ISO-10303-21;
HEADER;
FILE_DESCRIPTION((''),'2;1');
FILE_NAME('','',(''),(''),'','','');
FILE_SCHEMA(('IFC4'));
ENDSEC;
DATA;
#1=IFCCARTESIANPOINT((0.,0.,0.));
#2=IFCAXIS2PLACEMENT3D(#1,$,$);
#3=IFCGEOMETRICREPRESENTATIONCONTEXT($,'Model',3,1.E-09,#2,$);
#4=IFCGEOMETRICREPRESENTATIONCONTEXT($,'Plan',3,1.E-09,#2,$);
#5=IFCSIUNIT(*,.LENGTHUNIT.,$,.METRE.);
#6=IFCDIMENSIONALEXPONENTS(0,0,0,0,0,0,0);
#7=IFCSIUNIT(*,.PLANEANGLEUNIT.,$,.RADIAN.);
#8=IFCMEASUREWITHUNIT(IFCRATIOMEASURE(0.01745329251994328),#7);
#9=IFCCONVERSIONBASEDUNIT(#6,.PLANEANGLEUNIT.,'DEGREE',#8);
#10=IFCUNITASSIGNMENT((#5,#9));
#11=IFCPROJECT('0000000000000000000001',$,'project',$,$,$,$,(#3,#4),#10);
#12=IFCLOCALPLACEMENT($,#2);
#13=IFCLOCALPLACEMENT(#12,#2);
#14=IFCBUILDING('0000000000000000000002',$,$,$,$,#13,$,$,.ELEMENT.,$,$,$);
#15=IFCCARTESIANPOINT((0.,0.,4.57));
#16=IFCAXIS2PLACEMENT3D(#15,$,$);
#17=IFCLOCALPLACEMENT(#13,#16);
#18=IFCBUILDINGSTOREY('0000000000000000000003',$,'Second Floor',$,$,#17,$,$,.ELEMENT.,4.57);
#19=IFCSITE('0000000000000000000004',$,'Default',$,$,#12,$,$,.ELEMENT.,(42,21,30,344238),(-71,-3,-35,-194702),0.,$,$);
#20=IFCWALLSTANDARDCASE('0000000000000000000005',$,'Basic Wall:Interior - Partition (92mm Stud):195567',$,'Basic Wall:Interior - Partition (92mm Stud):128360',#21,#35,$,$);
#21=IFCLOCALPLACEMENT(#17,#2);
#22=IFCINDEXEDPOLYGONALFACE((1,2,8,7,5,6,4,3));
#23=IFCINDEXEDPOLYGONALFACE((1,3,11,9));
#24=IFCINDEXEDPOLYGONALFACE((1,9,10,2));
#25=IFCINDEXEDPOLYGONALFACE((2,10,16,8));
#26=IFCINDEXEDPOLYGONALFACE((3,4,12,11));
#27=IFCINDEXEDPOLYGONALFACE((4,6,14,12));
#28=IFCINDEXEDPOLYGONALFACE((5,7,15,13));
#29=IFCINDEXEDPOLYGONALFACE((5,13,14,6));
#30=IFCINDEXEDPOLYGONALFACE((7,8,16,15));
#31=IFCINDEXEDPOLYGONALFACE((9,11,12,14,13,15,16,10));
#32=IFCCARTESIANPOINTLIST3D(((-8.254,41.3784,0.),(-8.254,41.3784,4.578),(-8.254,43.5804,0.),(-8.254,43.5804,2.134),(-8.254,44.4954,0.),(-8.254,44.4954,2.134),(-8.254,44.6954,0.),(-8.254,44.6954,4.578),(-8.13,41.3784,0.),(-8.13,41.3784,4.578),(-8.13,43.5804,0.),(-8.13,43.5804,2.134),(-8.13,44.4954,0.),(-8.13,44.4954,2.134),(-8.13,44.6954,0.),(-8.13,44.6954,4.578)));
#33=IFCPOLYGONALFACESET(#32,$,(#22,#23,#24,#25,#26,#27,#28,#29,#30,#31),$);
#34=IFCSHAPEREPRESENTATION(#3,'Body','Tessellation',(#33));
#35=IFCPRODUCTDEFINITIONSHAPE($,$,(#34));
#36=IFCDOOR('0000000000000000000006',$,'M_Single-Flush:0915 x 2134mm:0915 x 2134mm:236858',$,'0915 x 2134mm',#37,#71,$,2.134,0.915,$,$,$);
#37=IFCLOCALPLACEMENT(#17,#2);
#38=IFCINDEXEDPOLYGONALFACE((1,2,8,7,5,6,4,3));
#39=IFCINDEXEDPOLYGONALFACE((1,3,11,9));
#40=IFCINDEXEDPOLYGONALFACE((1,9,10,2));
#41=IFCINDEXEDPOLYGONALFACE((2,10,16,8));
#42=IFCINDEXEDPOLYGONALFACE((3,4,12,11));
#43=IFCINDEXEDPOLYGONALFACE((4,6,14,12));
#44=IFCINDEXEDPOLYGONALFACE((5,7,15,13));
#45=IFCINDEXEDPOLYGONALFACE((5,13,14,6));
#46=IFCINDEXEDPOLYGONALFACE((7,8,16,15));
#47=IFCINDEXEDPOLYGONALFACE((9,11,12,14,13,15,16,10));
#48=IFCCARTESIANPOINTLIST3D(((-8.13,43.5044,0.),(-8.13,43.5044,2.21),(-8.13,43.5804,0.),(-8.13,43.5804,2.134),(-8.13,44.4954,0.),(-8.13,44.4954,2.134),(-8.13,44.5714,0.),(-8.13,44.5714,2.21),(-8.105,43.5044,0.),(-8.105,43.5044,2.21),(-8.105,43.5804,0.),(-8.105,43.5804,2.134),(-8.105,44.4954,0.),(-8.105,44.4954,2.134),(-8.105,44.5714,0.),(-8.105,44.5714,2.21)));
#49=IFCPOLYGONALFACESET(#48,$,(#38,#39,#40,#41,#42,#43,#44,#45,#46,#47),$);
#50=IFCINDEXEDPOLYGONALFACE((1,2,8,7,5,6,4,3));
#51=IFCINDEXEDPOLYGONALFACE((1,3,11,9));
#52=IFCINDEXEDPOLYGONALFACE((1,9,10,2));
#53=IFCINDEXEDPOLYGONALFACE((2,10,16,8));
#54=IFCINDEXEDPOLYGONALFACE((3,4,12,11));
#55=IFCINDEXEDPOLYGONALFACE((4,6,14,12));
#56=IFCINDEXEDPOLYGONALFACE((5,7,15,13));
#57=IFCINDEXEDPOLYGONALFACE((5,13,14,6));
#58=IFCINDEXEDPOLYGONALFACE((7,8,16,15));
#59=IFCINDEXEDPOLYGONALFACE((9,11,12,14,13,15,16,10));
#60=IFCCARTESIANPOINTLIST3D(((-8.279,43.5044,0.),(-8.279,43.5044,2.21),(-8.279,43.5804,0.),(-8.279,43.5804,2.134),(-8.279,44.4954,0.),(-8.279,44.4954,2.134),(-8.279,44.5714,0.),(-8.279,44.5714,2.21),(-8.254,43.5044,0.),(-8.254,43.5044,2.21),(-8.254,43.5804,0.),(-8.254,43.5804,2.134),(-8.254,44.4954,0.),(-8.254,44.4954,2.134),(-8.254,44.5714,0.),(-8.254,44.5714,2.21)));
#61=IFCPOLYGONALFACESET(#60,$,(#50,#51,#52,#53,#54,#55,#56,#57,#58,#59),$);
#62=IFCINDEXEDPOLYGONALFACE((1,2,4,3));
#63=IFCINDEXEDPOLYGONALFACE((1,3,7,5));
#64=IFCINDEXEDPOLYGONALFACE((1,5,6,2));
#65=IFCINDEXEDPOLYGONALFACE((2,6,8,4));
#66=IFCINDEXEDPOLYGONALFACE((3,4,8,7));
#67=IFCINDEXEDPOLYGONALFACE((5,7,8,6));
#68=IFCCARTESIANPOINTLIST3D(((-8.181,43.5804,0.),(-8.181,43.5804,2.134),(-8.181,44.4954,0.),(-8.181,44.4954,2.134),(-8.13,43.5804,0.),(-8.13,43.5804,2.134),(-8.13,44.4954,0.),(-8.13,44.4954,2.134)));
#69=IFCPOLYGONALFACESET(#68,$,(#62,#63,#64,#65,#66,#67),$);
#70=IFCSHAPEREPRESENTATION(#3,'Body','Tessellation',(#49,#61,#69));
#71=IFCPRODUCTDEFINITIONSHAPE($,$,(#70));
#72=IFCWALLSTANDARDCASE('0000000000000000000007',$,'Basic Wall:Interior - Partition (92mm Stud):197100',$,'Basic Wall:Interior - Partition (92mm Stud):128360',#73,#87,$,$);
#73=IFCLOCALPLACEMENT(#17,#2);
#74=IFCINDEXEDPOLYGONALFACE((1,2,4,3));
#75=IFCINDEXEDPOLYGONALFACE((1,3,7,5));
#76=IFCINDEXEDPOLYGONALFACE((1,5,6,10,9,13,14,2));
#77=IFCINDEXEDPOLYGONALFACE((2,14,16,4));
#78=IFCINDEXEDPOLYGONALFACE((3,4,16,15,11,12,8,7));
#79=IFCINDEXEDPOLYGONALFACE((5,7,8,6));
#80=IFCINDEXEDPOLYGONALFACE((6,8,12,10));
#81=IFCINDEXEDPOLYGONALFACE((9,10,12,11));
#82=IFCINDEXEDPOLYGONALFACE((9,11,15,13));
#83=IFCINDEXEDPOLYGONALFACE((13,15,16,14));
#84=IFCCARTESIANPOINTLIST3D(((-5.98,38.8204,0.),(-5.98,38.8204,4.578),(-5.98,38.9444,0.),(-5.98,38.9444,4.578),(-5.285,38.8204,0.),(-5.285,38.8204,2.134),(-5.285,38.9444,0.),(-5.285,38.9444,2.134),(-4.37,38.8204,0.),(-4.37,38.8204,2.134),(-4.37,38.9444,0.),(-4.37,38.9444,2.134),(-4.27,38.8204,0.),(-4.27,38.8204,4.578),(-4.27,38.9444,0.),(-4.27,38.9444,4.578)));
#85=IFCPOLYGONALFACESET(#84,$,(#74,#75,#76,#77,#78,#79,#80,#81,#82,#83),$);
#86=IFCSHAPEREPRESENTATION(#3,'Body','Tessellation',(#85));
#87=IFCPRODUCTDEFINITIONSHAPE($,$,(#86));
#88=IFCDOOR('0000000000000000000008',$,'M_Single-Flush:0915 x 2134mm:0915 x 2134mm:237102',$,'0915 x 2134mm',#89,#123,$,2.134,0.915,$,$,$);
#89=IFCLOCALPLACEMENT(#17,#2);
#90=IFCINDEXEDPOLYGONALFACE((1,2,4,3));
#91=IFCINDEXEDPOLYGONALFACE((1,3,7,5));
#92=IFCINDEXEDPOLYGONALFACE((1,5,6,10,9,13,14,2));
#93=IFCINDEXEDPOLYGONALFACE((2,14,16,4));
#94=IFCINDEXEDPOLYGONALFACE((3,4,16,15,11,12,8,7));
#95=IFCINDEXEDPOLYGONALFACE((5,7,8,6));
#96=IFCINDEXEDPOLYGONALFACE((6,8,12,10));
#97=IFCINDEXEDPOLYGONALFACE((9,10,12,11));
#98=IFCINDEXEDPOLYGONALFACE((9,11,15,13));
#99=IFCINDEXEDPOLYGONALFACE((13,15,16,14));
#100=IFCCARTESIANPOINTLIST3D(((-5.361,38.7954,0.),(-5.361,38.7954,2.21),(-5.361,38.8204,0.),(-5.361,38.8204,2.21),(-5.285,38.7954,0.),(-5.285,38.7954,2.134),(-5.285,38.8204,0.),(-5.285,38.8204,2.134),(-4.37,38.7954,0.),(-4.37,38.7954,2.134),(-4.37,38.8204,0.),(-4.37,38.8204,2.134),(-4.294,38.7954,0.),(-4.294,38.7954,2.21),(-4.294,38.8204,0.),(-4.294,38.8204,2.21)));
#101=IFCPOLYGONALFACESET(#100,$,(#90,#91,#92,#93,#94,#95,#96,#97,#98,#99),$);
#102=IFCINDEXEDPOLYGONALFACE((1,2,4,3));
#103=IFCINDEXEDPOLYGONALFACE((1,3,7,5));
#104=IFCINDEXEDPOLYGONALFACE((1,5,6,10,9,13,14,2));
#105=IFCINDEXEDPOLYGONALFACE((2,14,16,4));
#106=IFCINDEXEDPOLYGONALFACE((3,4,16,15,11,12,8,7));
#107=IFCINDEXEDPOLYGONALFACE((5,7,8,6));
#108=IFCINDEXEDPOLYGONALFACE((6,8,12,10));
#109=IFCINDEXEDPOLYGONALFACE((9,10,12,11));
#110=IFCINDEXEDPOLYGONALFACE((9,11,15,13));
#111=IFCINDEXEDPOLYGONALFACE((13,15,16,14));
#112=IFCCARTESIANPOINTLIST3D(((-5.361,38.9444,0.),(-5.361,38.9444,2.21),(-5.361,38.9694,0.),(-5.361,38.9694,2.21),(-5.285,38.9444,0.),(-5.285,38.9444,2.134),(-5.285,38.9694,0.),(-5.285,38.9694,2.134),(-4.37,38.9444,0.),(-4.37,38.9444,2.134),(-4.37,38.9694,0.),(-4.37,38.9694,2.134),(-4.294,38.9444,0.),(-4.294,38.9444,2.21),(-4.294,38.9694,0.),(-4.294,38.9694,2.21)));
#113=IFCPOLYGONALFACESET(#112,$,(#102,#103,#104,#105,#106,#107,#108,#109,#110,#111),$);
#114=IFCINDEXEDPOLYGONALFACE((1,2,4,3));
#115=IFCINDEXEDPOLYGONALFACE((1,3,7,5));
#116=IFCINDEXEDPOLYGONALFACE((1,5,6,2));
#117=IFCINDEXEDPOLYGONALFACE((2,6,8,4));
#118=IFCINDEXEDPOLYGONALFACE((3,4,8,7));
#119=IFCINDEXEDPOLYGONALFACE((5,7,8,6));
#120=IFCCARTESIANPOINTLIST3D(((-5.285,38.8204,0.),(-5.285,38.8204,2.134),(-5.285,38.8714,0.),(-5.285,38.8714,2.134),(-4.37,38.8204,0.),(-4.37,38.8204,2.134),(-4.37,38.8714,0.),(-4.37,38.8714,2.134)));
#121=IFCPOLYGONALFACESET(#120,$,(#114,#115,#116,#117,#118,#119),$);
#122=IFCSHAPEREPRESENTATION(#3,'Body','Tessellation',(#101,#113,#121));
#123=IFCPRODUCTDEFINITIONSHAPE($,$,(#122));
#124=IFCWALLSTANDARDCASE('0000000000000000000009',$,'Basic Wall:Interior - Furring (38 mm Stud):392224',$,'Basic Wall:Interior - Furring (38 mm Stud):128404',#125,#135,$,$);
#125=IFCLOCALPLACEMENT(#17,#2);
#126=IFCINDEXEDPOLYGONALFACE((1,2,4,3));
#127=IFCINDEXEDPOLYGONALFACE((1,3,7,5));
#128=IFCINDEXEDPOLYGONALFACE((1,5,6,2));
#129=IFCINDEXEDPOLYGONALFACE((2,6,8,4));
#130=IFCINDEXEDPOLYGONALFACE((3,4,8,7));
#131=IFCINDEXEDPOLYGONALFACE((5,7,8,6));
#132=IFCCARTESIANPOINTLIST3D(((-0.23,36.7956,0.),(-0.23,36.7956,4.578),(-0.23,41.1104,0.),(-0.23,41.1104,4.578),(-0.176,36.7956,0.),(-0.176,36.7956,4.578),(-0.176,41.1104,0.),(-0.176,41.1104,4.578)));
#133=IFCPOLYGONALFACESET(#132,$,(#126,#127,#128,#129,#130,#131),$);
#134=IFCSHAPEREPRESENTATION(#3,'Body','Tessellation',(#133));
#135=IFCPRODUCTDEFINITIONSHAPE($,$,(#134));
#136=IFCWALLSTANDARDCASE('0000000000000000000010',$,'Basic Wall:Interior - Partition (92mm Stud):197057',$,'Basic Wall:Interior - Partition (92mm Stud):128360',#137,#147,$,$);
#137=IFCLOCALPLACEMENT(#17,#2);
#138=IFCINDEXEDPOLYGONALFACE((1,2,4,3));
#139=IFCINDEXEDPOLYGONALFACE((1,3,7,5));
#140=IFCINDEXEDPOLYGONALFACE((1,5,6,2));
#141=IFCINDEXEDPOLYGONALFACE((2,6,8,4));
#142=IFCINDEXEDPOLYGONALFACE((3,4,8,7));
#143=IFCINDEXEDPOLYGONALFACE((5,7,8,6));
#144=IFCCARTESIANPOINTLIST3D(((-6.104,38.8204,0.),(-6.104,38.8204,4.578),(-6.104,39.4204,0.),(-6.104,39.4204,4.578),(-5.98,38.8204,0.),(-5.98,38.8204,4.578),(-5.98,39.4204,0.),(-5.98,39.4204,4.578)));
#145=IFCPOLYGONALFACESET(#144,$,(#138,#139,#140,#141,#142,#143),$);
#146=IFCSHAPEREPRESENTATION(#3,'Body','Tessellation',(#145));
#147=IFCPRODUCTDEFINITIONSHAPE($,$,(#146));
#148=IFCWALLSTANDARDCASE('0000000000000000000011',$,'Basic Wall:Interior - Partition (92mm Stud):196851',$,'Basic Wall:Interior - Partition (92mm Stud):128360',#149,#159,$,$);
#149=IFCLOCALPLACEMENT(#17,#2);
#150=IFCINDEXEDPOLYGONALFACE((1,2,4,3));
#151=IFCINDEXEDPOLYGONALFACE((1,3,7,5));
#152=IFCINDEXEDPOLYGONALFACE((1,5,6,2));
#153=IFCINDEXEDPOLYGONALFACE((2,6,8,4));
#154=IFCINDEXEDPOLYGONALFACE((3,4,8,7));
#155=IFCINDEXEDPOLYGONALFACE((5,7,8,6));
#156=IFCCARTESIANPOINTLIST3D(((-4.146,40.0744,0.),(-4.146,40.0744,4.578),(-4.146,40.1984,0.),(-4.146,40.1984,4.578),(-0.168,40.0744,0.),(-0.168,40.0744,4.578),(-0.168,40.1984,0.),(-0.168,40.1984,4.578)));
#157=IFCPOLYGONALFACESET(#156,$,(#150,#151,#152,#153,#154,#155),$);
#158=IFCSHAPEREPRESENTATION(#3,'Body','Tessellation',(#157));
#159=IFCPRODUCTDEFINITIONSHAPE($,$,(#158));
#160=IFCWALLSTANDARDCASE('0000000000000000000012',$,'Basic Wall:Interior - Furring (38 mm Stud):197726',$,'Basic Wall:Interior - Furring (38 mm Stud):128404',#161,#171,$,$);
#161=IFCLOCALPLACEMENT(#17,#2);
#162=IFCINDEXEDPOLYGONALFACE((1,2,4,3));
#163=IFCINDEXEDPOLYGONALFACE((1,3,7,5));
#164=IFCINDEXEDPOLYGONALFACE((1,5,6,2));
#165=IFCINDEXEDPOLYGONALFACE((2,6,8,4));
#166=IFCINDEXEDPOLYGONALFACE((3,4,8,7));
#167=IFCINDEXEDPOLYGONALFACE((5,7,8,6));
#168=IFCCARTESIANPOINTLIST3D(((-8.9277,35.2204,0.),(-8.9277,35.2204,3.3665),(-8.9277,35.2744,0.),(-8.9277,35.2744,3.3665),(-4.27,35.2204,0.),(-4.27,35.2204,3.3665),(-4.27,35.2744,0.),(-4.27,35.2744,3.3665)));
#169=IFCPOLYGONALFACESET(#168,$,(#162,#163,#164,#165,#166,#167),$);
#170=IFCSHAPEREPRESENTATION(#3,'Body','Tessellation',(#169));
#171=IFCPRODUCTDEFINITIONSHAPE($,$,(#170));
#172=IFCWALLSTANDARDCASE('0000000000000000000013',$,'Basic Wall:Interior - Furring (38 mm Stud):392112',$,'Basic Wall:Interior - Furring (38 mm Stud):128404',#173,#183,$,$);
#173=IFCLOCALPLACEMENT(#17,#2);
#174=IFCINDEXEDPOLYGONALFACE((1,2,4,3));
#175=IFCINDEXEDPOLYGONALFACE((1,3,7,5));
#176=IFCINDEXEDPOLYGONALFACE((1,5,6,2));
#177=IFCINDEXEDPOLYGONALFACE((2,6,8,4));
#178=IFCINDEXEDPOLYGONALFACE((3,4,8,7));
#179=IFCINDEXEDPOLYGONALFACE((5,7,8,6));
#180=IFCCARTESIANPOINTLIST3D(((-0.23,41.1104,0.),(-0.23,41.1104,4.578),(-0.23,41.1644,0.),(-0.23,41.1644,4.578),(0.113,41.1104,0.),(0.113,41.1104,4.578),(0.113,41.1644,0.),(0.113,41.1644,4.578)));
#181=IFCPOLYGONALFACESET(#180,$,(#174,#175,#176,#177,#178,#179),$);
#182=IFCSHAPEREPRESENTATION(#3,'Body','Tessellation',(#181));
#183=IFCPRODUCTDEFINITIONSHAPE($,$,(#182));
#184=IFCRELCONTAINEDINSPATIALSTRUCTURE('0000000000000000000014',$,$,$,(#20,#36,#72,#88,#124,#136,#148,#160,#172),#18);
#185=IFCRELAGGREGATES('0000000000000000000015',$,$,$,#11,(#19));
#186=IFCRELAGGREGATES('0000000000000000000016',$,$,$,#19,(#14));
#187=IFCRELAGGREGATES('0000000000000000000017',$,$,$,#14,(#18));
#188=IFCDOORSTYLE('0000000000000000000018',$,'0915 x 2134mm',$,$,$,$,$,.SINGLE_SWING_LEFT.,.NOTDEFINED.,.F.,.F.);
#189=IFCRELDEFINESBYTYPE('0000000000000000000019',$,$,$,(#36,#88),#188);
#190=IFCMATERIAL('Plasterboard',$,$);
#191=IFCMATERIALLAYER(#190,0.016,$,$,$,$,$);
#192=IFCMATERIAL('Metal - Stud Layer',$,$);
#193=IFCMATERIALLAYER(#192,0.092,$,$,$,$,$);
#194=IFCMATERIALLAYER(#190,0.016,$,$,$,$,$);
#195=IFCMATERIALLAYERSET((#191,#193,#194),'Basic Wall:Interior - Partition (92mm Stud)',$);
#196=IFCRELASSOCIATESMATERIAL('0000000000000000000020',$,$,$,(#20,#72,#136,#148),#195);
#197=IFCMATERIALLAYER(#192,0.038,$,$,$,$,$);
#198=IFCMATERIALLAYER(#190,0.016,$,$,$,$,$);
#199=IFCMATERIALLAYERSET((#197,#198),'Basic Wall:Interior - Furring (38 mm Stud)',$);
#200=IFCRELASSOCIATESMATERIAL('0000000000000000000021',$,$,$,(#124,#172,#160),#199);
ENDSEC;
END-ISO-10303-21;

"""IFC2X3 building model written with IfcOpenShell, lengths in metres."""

from ifc_helpers import new_model, entity, si_unit, converted_unit, frame, frame_2d, origin, origin_2d_with_axis, place, context, project, spatial, polyline, rectangle, outline, extrude, source, transform, mapped, material, layer, layer_set, layer_usage, type_object, type_shapes, element, fill, save


model = new_model("IFC2X3")

# Units and contexts
model_context = context("Model", 3, precision=1e-09, world=origin())
plan_context = context("Plan", 3, precision=1e-09, world=origin())
ifc_project = project(units=[si_unit("LENGTHUNIT", "METRE"), converted_unit("PLANEANGLEUNIT", "DEGREE", entity("IfcRatioMeasure", 0.01745329251994328), si_unit("PLANEANGLEUNIT", "RADIAN"), dimensions=[0, 0, 0, 0, 0, 0, 0])], contexts=[model_context, plan_context])

# Site, building, storey
site_placement = place(None, origin())
site = spatial("IfcSite", under=ifc_project, at=site_placement, Name="Default", CompositionType="ELEMENT", RefLatitude=(42, 21, 30, 344238), RefLongitude=(-71, -3, -35, -194702), RefElevation=0.0)
building_placement = place(site_placement, origin())
building = spatial("IfcBuilding", under=site, at=building_placement, CompositionType="ELEMENT")
storey_placement = place(building_placement, frame((0.0, 0.0, 4.57)))
storey = spatial("IfcBuildingStorey", under=building, at=storey_placement, Name="Second Floor", CompositionType="ELEMENT", Elevation=4.57)

# Shared definitions
ifc_material_1 = material(Name="Plasterboard")
ifc_layer_1 = layer(ifc_material_1, 0.016)
ifc_material_2 = material(Name="Metal - Stud Layer")
ifc_layer_2 = layer(ifc_material_2, 0.092)
ifc_layer_3 = layer(ifc_material_1, 0.016)
ifc_layer_set_1 = layer_set([ifc_layer_1, ifc_layer_2, ifc_layer_3], Name="Basic Wall:Interior - Partition (92mm Stud)")
ifc_layer_usage_1 = layer_usage(ifc_layer_set_1, "AXIS2", "NEGATIVE", 0.062)
door_style_1 = type_object("IfcDoorStyle", Name="0915 x 2134mm", ConstructionType="NOTDEFINED", OperationType="SINGLE_SWING_LEFT", ParameterTakesPrecedence=False, Sizeable=False)
shared_shape_1 = source(origin(), model_context, "Body", "SweptSolid", [
    extrude(outline(polyline([(-0.5335, -1.124), (0.5335, -1.124), (0.5335, 1.086), (0.4575, 1.086), (0.4575, -1.048), (-0.4575, -1.048), (-0.4575, 1.086), (-0.5335, 1.086), (-0.5335, -1.124)])), frame((0.4575, 0.149, 1.086), z_axis=(0.0, -1.0, 0.0), x_axis=(-1.0, 0.0, 0.0)), (0.0, 0.0, 1.0), 0.025),
    extrude(outline(polyline([(-1.124, -0.5335), (1.086, -0.5335), (1.086, -0.4575), (-1.048, -0.4575), (-1.048, 0.4575), (1.086, 0.4575), (1.086, 0.5335), (-1.124, 0.5335), (-1.124, -0.5335)])), frame((0.4575, 0.0, 1.086), z_axis=(0.0, -1.0, 0.0), x_axis=(0.0, 0.0, -1.0)), (0.0, 0.0, 1.0), 0.025),
    extrude(rectangle(XDim=0.915, YDim=0.051, at=origin_2d_with_axis()), frame((0.4575, 0.0985, 0.0)), (0.0, 0.0, 1.0), 2.134),
])
type_shapes(door_style_1, [shared_shape_1])

# Wall, opening, door
wall_1_placement = place(storey_placement, frame((-8.192, 41.3784, 0.0), z_axis=(0.0, 0.0, 1.0), x_axis=(0.0, 1.0, 0.0)))
wall_1 = element("IfcWallStandardCase", 1, at=wall_1_placement, inside=storey, material=ifc_layer_usage_1, Name="Basic Wall:Interior - Partition (92mm Stud):195567", ObjectType="Basic Wall:Interior - Partition (92mm Stud):128360", context=model_context, shape_type="SweptSolid", body=[
    extrude(rectangle(XDim=3.317, YDim=0.124, at=frame_2d((1.6585, 0.0), x_axis=(-1.0, 0.0))), origin(), (0.0, 0.0, 1.0), 4.578),
])
opening_1_placement = place(wall_1_placement, frame((3.117, 0.062, 0.0)))
opening_1 = element("IfcOpeningElement", 2, at=opening_1_placement, cuts=wall_1, ObjectType="Opening", context=model_context, shape_type="SweptSolid", body=[
    extrude(rectangle(XDim=0.915, YDim=2.134, at=frame_2d((1.067, 0.4575), x_axis=(0.0, -1.0))), frame((0.0, 0.0, 0.0), z_axis=(0.0, -1.0, 0.0), x_axis=(0.0, 0.0, 1.0)), (0.0, 0.0, 1.0), 0.124),
])
door_1_placement = place(opening_1_placement, frame((0.0, 0.0, 0.0), z_axis=(0.0, 0.0, 1.0), x_axis=(-1.0, 0.0, 0.0)))
door_1 = element("IfcDoor", 3, at=door_1_placement, inside=storey, type_object=door_style_1, Name="M_Single-Flush:0915 x 2134mm:0915 x 2134mm:236858", ObjectType="0915 x 2134mm", OverallHeight=2.134, OverallWidth=0.915, context=model_context, shape_type="MappedRepresentation", body=[
    mapped(shared_shape_1, transform((0.0, 0.0, 0.0), scale=1.0)),
])
fill(opening_1, door_1)

# Shared definitions
ifc_layer_4 = layer(ifc_material_2, 0.038)
ifc_layer_5 = layer(ifc_material_1, 0.016)
ifc_layer_set_2 = layer_set([ifc_layer_4, ifc_layer_5], Name="Basic Wall:Interior - Furring (38 mm Stud)")
ifc_layer_usage_2 = layer_usage(ifc_layer_set_2, "AXIS2", "NEGATIVE", 0.027)

# Wall, opening, door
wall_2_placement = place(storey_placement, frame((-5.98, 38.8824, 0.0)))
wall_2 = element("IfcWallStandardCase", 4, at=wall_2_placement, inside=storey, material=ifc_layer_usage_1, Name="Basic Wall:Interior - Partition (92mm Stud):197100", ObjectType="Basic Wall:Interior - Partition (92mm Stud):128360", context=model_context, shape_type="SweptSolid", body=[
    extrude(rectangle(XDim=1.71, YDim=0.124, at=frame_2d((0.855, 0.0), x_axis=(-1.0, 0.0))), origin(), (0.0, 0.0, 1.0), 4.578),
])
opening_2_placement = place(wall_2_placement, frame((1.61, 0.062, 0.0)))
opening_2 = element("IfcOpeningElement", 5, at=opening_2_placement, cuts=wall_2, ObjectType="Opening", context=model_context, shape_type="SweptSolid", body=[
    extrude(rectangle(XDim=0.915, YDim=2.134, at=frame_2d((1.067, 0.4575), x_axis=(0.0, -1.0))), frame((0.0, 0.0, 0.0), z_axis=(0.0, -1.0, 0.0), x_axis=(0.0, 0.0, 1.0)), (0.0, 0.0, 1.0), 0.124),
])
door_2_placement = place(opening_2_placement, frame((0.0, 0.0, 0.0), z_axis=(0.0, 0.0, 1.0), x_axis=(-1.0, 0.0, 0.0)))
door_2 = element("IfcDoor", 6, at=door_2_placement, inside=storey, type_object=door_style_1, Name="M_Single-Flush:0915 x 2134mm:0915 x 2134mm:237102", ObjectType="0915 x 2134mm", OverallHeight=2.134, OverallWidth=0.915, context=model_context, shape_type="MappedRepresentation", body=[
    mapped(shared_shape_1, transform((0.0, 0.0, 0.0), scale=1.0)),
])
fill(opening_2, door_2)

# Walls
wall_3_placement = place(storey_placement, frame((-0.203, 41.1104, 0.0), z_axis=(0.0, 0.0, 1.0), x_axis=(0.0, -1.0, 0.0)))
element("IfcWallStandardCase", 7, at=wall_3_placement, inside=storey, material=ifc_layer_usage_2, Name="Basic Wall:Interior - Furring (38 mm Stud):392224", ObjectType="Basic Wall:Interior - Furring (38 mm Stud):128404", context=model_context, shape_type="SweptSolid", body=[
    extrude(rectangle(XDim=4.3148, YDim=0.054, at=frame_2d((2.1574, 0.0), x_axis=(-1.0, 0.0))), origin(), (0.0, 0.0, 1.0), 4.578),
])
wall_4_placement = place(storey_placement, frame((-6.042, 39.4204, 0.0), z_axis=(0.0, 0.0, 1.0), x_axis=(0.0, -1.0, 0.0)))
element("IfcWallStandardCase", 8, at=wall_4_placement, inside=storey, material=ifc_layer_usage_1, Name="Basic Wall:Interior - Partition (92mm Stud):197057", ObjectType="Basic Wall:Interior - Partition (92mm Stud):128360", context=model_context, shape_type="SweptSolid", body=[
    extrude(rectangle(XDim=0.6, YDim=0.124, at=frame_2d((0.3, 0.0), x_axis=(-1.0, 0.0))), origin(), (0.0, 0.0, 1.0), 4.578),
])

# Walls
wall_5_placement = place(storey_placement, frame((-0.168, 40.1364, 0.0), z_axis=(0.0, 0.0, 1.0), x_axis=(-1.0, 0.0, 0.0)))
element("IfcWallStandardCase", 9, at=wall_5_placement, inside=storey, material=ifc_layer_usage_1, Name="Basic Wall:Interior - Partition (92mm Stud):196851", ObjectType="Basic Wall:Interior - Partition (92mm Stud):128360", context=model_context, shape_type="SweptSolid", body=[
    extrude(rectangle(XDim=3.978, YDim=0.124, at=frame_2d((1.989, 0.0), x_axis=(-1.0, 0.0))), origin(), (0.0, 0.0, 1.0), 4.578),
])
ifc_layer_usage_3 = layer_usage(ifc_layer_set_2, "AXIS2", "POSITIVE", -0.027)
wall_6_placement = place(storey_placement, frame((-8.9277, 35.2474, 0.0)))
element("IfcWallStandardCase", 10, at=wall_6_placement, inside=storey, material=ifc_layer_usage_3, Name="Basic Wall:Interior - Furring (38 mm Stud):197726", ObjectType="Basic Wall:Interior - Furring (38 mm Stud):128404", context=model_context, shape_type="SweptSolid", body=[
    extrude(rectangle(XDim=4.6577, YDim=0.054, at=frame_2d((2.3289, 0.0), x_axis=(-1.0, 0.0))), origin(), (0.0, 0.0, 1.0), 3.3665),
])
wall_7_placement = place(storey_placement, frame((0.113, 41.1374, 0.0), z_axis=(0.0, 0.0, 1.0), x_axis=(-1.0, 0.0, 0.0)))
element("IfcWallStandardCase", 11, at=wall_7_placement, inside=storey, material=ifc_layer_usage_2, Name="Basic Wall:Interior - Furring (38 mm Stud):392112", ObjectType="Basic Wall:Interior - Furring (38 mm Stud):128404", context=model_context, shape_type="SweptSolid", body=[
    extrude(rectangle(XDim=0.343, YDim=0.054, at=frame_2d((0.1715, 0.0), x_axis=(-1.0, 0.0))), origin(), (0.0, 0.0, 1.0), 4.578),
])

save(model, "model.ifc")
